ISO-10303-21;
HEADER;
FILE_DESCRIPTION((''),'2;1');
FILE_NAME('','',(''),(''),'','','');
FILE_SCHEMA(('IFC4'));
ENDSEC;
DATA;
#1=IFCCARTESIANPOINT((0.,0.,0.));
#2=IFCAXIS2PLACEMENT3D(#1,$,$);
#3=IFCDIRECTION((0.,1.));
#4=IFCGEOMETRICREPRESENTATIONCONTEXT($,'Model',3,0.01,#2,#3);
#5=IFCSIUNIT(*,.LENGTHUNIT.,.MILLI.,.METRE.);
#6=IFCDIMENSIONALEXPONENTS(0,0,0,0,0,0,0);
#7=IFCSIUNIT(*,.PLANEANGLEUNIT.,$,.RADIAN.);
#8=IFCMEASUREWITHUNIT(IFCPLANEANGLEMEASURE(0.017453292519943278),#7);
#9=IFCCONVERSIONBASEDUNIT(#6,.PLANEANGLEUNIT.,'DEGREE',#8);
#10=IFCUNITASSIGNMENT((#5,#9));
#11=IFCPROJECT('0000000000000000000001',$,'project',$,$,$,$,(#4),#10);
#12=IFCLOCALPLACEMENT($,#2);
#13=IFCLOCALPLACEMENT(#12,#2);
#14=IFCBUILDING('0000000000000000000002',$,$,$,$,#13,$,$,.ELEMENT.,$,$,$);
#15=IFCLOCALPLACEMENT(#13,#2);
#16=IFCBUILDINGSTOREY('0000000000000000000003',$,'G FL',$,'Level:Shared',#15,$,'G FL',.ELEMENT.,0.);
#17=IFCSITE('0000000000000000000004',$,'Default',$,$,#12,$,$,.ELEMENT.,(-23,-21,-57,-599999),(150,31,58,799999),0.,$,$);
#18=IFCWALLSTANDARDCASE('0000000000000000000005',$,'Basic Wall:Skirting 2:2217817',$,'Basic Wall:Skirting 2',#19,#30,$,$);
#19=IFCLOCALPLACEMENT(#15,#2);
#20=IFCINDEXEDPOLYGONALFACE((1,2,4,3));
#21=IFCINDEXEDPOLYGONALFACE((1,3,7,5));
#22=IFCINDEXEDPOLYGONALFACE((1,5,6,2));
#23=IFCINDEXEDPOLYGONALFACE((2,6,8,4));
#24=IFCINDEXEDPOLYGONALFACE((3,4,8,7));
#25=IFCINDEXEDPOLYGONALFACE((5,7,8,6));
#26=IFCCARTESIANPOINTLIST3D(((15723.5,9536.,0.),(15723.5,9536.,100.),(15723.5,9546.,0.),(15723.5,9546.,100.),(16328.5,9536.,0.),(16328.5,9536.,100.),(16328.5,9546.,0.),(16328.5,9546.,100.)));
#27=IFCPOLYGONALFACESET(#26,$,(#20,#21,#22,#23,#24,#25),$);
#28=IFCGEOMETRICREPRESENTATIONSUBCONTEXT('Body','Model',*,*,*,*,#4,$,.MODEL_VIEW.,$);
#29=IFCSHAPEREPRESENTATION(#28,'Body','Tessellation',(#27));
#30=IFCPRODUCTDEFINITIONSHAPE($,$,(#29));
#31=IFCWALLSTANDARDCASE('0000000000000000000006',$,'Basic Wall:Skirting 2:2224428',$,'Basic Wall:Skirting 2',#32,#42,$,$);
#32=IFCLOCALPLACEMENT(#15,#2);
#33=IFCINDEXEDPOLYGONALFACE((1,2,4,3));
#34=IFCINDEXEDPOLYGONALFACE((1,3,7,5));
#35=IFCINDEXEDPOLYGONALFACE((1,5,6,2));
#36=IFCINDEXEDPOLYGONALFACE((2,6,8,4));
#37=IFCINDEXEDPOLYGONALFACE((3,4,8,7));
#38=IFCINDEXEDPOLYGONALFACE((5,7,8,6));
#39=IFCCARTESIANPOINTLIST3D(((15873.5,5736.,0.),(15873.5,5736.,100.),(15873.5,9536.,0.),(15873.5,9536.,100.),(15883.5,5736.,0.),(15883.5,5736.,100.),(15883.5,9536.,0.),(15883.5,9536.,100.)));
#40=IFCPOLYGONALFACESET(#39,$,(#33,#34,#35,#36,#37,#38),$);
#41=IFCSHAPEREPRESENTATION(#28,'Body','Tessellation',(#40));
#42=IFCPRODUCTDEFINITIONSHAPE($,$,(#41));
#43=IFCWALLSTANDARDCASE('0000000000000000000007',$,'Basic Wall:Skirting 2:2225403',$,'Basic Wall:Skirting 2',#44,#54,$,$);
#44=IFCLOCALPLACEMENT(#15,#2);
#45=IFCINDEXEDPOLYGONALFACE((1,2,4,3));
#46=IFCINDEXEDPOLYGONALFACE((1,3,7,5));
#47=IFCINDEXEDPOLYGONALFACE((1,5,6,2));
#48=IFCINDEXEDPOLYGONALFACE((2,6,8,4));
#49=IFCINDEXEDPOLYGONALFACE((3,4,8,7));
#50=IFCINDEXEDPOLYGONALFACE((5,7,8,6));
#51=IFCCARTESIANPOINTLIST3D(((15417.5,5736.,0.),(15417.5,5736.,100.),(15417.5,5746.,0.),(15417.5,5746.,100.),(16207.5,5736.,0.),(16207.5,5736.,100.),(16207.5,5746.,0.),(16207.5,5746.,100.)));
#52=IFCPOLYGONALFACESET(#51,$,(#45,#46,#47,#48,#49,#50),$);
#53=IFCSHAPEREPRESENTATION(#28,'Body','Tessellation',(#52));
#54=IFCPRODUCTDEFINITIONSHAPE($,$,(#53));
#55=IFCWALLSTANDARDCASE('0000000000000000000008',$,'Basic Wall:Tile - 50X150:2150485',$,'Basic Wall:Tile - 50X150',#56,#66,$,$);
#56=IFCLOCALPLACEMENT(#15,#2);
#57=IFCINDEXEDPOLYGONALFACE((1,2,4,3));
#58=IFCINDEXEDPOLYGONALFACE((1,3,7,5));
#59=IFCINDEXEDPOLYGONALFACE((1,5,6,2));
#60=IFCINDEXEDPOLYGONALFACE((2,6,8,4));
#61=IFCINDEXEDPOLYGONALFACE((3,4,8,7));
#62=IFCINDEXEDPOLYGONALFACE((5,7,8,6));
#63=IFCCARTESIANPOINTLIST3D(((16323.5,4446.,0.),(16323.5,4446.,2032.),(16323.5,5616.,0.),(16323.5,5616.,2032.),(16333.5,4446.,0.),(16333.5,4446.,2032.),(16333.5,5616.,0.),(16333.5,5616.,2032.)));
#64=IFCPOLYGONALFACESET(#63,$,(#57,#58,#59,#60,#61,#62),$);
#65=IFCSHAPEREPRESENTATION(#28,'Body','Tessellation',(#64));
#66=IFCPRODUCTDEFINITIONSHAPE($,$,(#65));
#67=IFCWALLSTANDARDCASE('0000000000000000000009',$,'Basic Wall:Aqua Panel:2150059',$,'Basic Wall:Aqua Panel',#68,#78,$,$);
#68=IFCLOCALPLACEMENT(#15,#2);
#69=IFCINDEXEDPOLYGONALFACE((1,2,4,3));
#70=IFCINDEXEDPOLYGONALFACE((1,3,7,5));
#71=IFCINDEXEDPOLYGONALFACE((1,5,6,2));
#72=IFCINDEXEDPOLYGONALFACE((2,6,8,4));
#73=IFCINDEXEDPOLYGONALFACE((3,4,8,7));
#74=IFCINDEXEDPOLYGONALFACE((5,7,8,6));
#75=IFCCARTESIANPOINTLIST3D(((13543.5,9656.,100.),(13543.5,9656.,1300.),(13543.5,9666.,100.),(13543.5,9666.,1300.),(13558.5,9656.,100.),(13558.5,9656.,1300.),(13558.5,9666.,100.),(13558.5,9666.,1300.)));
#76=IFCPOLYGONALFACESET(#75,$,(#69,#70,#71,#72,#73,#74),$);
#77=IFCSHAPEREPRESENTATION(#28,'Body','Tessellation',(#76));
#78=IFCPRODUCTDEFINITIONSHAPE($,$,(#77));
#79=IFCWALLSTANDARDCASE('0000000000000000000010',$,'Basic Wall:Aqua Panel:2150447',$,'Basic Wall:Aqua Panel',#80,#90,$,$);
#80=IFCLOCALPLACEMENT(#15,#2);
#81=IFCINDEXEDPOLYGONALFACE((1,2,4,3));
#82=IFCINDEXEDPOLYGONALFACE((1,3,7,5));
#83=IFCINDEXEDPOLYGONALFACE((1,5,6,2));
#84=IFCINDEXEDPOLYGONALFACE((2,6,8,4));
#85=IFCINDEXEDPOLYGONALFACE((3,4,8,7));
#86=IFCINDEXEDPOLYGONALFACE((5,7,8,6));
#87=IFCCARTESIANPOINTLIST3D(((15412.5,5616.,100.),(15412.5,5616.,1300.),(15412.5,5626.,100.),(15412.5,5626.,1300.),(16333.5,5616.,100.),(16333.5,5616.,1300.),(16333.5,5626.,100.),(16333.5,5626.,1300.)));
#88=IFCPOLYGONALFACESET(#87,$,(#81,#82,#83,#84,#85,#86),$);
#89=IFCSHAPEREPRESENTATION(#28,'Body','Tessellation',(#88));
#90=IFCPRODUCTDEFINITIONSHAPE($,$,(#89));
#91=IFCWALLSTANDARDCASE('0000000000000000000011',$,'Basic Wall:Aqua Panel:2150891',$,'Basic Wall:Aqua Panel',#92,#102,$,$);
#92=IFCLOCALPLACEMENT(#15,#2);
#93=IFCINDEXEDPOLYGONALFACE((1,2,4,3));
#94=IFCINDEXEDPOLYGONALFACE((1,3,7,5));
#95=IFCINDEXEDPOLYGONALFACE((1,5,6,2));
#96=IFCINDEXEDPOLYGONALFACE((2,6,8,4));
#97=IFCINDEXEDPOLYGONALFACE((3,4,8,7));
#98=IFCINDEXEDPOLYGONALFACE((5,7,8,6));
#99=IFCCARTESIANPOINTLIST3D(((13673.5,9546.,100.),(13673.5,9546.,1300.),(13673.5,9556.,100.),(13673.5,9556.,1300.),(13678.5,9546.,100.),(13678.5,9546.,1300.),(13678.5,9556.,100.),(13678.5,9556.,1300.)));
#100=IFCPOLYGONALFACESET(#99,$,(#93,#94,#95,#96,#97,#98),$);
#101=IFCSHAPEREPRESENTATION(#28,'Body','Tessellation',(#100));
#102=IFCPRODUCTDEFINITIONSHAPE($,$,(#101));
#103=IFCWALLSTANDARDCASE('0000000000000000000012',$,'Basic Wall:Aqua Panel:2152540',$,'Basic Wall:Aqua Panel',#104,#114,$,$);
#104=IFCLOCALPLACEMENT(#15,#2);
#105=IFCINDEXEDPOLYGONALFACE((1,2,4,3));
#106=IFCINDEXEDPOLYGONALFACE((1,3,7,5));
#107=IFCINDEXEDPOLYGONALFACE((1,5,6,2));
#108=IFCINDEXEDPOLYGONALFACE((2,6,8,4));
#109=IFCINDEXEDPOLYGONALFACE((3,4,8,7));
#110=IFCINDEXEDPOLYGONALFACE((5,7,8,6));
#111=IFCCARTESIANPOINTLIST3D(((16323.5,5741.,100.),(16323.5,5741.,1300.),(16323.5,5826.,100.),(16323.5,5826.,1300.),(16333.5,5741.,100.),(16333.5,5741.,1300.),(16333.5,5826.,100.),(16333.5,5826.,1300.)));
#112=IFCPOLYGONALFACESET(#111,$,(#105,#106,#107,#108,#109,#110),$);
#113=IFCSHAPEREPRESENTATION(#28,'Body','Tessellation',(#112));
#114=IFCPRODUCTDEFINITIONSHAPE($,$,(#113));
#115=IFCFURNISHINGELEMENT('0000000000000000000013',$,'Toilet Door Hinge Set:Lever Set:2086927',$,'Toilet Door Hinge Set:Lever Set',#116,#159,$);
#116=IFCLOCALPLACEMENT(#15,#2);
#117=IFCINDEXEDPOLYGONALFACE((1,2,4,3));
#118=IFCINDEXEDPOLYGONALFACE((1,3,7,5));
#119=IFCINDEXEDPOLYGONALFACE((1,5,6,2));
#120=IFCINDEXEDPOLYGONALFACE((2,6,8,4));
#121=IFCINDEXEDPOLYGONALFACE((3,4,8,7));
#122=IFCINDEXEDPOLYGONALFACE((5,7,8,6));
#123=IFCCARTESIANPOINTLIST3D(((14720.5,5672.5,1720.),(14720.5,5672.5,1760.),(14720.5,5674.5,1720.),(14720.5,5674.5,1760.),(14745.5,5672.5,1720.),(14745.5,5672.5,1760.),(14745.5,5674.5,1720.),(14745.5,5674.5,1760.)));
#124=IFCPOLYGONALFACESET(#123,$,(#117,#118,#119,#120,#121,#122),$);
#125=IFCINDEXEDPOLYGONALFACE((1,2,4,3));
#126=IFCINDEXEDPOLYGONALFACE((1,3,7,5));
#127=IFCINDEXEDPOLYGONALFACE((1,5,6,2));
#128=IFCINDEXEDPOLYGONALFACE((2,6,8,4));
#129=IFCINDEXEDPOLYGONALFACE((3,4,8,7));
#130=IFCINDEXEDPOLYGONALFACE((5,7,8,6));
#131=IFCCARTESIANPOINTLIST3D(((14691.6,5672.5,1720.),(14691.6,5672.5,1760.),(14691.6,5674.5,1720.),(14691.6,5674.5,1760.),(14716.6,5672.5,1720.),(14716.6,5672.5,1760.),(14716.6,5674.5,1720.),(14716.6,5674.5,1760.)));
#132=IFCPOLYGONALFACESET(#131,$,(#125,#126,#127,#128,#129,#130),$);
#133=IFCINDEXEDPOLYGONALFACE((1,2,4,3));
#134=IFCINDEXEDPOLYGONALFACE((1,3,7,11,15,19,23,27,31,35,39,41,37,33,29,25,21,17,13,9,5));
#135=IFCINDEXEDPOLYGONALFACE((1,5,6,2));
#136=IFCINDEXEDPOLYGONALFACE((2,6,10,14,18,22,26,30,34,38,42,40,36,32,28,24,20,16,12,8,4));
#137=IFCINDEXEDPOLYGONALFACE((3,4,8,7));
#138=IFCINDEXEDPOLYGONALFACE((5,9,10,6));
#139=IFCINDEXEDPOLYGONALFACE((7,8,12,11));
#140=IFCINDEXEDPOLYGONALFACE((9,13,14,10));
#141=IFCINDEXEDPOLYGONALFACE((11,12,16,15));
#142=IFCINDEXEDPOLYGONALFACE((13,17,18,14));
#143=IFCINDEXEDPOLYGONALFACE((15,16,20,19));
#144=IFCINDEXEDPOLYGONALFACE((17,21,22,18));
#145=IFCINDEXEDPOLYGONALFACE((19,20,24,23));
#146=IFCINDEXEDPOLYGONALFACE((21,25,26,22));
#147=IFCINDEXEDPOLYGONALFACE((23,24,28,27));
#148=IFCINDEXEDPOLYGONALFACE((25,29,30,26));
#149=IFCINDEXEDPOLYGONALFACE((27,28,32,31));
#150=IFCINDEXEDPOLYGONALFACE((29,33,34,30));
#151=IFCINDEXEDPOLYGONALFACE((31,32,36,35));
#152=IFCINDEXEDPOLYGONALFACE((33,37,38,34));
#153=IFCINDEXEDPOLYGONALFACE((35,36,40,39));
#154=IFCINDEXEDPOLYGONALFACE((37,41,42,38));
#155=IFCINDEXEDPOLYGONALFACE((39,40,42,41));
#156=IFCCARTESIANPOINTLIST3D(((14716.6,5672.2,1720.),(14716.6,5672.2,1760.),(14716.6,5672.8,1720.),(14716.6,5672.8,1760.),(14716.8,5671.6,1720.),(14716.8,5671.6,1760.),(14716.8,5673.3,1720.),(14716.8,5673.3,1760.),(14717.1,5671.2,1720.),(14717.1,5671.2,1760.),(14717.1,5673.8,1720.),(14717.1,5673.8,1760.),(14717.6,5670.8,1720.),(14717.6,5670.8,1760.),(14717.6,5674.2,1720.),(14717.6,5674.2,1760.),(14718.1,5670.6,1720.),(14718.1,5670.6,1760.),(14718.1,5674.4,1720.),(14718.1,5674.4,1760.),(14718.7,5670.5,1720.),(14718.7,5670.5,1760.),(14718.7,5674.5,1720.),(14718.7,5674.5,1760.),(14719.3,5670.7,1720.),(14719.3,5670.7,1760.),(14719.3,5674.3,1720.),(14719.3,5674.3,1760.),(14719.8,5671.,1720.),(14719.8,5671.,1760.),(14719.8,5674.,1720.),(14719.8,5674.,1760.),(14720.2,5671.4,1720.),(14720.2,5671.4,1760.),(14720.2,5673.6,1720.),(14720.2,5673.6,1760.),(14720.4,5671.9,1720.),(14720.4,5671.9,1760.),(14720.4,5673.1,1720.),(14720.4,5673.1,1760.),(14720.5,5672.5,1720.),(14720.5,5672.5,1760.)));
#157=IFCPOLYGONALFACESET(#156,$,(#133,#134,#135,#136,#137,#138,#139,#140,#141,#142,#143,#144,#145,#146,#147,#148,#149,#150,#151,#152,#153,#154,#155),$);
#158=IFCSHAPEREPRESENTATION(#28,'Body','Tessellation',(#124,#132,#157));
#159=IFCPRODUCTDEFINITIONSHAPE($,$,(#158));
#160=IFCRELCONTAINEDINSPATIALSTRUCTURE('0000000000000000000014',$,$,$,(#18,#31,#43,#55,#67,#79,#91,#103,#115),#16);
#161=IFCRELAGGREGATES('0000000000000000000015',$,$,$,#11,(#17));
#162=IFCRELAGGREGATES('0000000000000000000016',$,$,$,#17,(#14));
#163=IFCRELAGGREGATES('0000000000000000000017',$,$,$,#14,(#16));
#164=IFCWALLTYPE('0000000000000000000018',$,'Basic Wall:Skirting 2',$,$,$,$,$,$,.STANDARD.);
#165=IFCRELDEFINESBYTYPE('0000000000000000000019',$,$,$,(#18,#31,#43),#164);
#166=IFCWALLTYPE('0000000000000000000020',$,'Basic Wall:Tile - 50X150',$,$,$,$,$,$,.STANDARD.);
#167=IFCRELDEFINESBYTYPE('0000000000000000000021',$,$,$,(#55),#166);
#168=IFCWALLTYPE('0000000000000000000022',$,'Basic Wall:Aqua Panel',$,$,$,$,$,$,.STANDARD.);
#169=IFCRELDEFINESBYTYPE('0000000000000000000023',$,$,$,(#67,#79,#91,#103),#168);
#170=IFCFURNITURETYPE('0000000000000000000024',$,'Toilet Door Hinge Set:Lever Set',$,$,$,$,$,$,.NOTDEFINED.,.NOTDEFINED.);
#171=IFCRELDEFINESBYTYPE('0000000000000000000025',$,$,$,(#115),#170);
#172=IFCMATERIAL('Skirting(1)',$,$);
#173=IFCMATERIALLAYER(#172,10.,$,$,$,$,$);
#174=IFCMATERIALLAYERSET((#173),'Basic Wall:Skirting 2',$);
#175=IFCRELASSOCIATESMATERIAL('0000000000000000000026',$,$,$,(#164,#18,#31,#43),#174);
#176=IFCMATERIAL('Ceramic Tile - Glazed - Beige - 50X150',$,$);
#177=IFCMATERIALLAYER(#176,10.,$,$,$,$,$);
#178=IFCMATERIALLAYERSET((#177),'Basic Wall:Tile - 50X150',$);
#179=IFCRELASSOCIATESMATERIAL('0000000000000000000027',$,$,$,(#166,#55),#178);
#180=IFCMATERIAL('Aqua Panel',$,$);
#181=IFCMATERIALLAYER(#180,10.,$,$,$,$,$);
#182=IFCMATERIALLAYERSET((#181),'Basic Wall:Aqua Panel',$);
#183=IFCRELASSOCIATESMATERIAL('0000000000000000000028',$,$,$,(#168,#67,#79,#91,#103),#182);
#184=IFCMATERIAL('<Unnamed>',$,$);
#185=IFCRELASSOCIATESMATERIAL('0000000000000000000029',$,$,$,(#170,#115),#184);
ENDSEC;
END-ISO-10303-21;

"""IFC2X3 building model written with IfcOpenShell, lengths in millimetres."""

from ifc_helpers import new_model, entity, si_unit, converted_unit, direction, frame, frame_2d, origin, place, context, subcontext, project, spatial, rectangle, circle, extrude, source, transform, mapped, material, layer, layer_set, layer_usage, type_object, type_shapes, element, save


model = new_model("IFC2X3")

# Units and contexts
model_context = context("Model", 3, precision=0.01, world=origin(), true_north=direction((0.0, 1.0)))
body_context = subcontext(model_context, "Body", "Model", "MODEL_VIEW")
ifc_project = project(units=[si_unit("LENGTHUNIT", "METRE", prefix="MILLI"), converted_unit("PLANEANGLEUNIT", "DEGREE", entity("IfcPlaneAngleMeasure", 0.017453292519943278), si_unit("PLANEANGLEUNIT", "RADIAN"), dimensions=[0, 0, 0, 0, 0, 0, 0])], contexts=[model_context])

# Site, building, storey
site_placement = place(None, origin())
site = spatial("IfcSite", under=ifc_project, at=site_placement, Name="Default", CompositionType="ELEMENT", RefLatitude=(-23, -21, -57, -599999), RefLongitude=(150, 31, 58, 799999), RefElevation=0.0)
building_placement = place(site_placement, origin())
building = spatial("IfcBuilding", under=site, at=building_placement, CompositionType="ELEMENT")
storey_placement = place(building_placement, origin())
storey = spatial("IfcBuildingStorey", under=building, at=storey_placement, Name="G FL", ObjectType="Level:Shared", LongName="G FL", CompositionType="ELEMENT", Elevation=0.0)

# Walls
ifc_material_1 = material(Name="Skirting(1)")
ifc_layer_1 = layer(ifc_material_1, 10.0)
ifc_layer_set_1 = layer_set([ifc_layer_1], Name="Basic Wall:Skirting 2")
wall_type_1 = type_object("IfcWallType", Name="Basic Wall:Skirting 2", PredefinedType="STANDARD", material=ifc_layer_set_1)
ifc_layer_usage_1 = layer_usage(ifc_layer_set_1, "AXIS2", "POSITIVE", -5.0)
wall_1_placement = place(storey_placement, frame((16328.5, 9541.0, 0.0), z_axis=(0.0, 0.0, 1.0), x_axis=(-1.0, 0.0, 0.0)))
element("IfcWallStandardCase", 1, at=wall_1_placement, inside=storey, type_object=wall_type_1, material=ifc_layer_usage_1, Name="Basic Wall:Skirting 2:2217817", ObjectType="Basic Wall:Skirting 2", context=body_context, shape_type="SweptSolid", body=[
    extrude(rectangle(XDim=605.0, YDim=10.0, at=frame_2d((302.5, 0.0), x_axis=(-1.0, 0.0))), origin(), (0.0, 0.0, 1.0), 100.0),
])
ifc_layer_usage_2 = layer_usage(ifc_layer_set_1, "AXIS2", "POSITIVE", -5.0)
wall_2_placement = place(storey_placement, frame((15878.5, 9536.0, 0.0), z_axis=(0.0, 0.0, 1.0), x_axis=(0.0, -1.0, 0.0)))
element("IfcWallStandardCase", 2, at=wall_2_placement, inside=storey, type_object=wall_type_1, material=ifc_layer_usage_2, Name="Basic Wall:Skirting 2:2224428", ObjectType="Basic Wall:Skirting 2", context=body_context, shape_type="SweptSolid", body=[
    extrude(rectangle(XDim=3800.0, YDim=10.0, at=frame_2d((1900.0, 0.0), x_axis=(-1.0, 0.0))), origin(), (0.0, 0.0, 1.0), 100.0),
])
ifc_layer_usage_3 = layer_usage(ifc_layer_set_1, "AXIS2", "POSITIVE", -5.0)
wall_3_placement = place(storey_placement, frame((15417.5, 5741.0, 0.0)))
element("IfcWallStandardCase", 3, at=wall_3_placement, inside=storey, type_object=wall_type_1, material=ifc_layer_usage_3, Name="Basic Wall:Skirting 2:2225403", ObjectType="Basic Wall:Skirting 2", context=body_context, shape_type="SweptSolid", body=[
    extrude(rectangle(XDim=790.0, YDim=10.0, at=frame_2d((395.0, 0.0), x_axis=(-1.0, 0.0))), origin(), (0.0, 0.0, 1.0), 100.0),
])
ifc_material_2 = material(Name="Ceramic Tile - Glazed - Beige - 50X150")
ifc_layer_2 = layer(ifc_material_2, 10.0)
ifc_layer_set_2 = layer_set([ifc_layer_2], Name="Basic Wall:Tile - 50X150")
ifc_layer_usage_4 = layer_usage(ifc_layer_set_2, "AXIS2", "NEGATIVE", 5.0)
wall_type_2 = type_object("IfcWallType", Name="Basic Wall:Tile - 50X150", PredefinedType="STANDARD", material=ifc_layer_set_2)
wall_4_placement = place(storey_placement, frame((16328.5, 5616.0, 0.0), z_axis=(0.0, 0.0, 1.0), x_axis=(0.0, -1.0, 0.0)))
element("IfcWallStandardCase", 4, at=wall_4_placement, inside=storey, type_object=wall_type_2, material=ifc_layer_usage_4, Name="Basic Wall:Tile - 50X150:2150485", ObjectType="Basic Wall:Tile - 50X150", context=body_context, shape_type="SweptSolid", body=[
    extrude(rectangle(XDim=1170.0, YDim=10.0, at=frame_2d((585.0, 0.0), x_axis=(-1.0, 0.0))), origin(), (0.0, 0.0, 1.0), 2032.0),
])
ifc_material_3 = material(Name="Aqua Panel")
ifc_layer_3 = layer(ifc_material_3, 10.0)
ifc_layer_set_3 = layer_set([ifc_layer_3], Name="Basic Wall:Aqua Panel")
ifc_layer_usage_5 = layer_usage(ifc_layer_set_3, "AXIS2", "NEGATIVE", 5.0)
wall_type_3 = type_object("IfcWallType", Name="Basic Wall:Aqua Panel", PredefinedType="STANDARD", material=ifc_layer_set_3)
wall_5_placement = place(storey_placement, frame((13558.5, 9661.0, 100.0), z_axis=(0.0, 0.0, 1.0), x_axis=(-1.0, 0.0, 0.0)))
element("IfcWallStandardCase", 5, at=wall_5_placement, inside=storey, type_object=wall_type_3, material=ifc_layer_usage_5, Name="Basic Wall:Aqua Panel:2150059", ObjectType="Basic Wall:Aqua Panel", context=body_context, shape_type="SweptSolid", body=[
    extrude(rectangle(XDim=15.0, YDim=10.0, at=frame_2d((0.0, 0.0), x_axis=(1.0, 0.0))), frame((7.5, 0.0, 0.0)), (0.0, 0.0, 1.0), 1200.0),
])
ifc_layer_usage_6 = layer_usage(ifc_layer_set_3, "AXIS2", "NEGATIVE", 5.0)
wall_6_placement = place(storey_placement, frame((15412.5, 5621.0, 100.0)))
element("IfcWallStandardCase", 6, at=wall_6_placement, inside=storey, type_object=wall_type_3, material=ifc_layer_usage_6, Name="Basic Wall:Aqua Panel:2150447", ObjectType="Basic Wall:Aqua Panel", context=body_context, shape_type="SweptSolid", body=[
    extrude(rectangle(XDim=921.0, YDim=10.0, at=frame_2d((460.5, 0.0), x_axis=(-1.0, 0.0))), origin(), (0.0, 0.0, 1.0), 1200.0),
])
ifc_layer_usage_7 = layer_usage(ifc_layer_set_3, "AXIS2", "NEGATIVE", 5.0)
wall_7_placement = place(storey_placement, frame((13673.5, 9551.0, 100.0)))
element("IfcWallStandardCase", 7, at=wall_7_placement, inside=storey, type_object=wall_type_3, material=ifc_layer_usage_7, Name="Basic Wall:Aqua Panel:2150891", ObjectType="Basic Wall:Aqua Panel", context=body_context, shape_type="SweptSolid", body=[
    extrude(rectangle(XDim=5.0, YDim=10.0, at=frame_2d((0.0, 0.0), x_axis=(1.0, 0.0))), frame((2.5, 0.0, 0.0), z_axis=(0.0, 0.0, 1.0), x_axis=(-1.0, 0.0, 0.0)), (0.0, 0.0, 1.0), 1200.0),
])
ifc_layer_usage_8 = layer_usage(ifc_layer_set_3, "AXIS2", "NEGATIVE", 5.0)
wall_8_placement = place(storey_placement, frame((16328.5, 5826.0, 100.0), z_axis=(0.0, 0.0, 1.0), x_axis=(0.0, -1.0, 0.0)))
element("IfcWallStandardCase", 8, at=wall_8_placement, inside=storey, type_object=wall_type_3, material=ifc_layer_usage_8, Name="Basic Wall:Aqua Panel:2152540", ObjectType="Basic Wall:Aqua Panel", context=body_context, shape_type="SweptSolid", body=[
    extrude(rectangle(XDim=85.0, YDim=10.0, at=frame_2d((42.5, 0.0), x_axis=(-1.0, 0.0))), origin(), (0.0, 0.0, 1.0), 1200.0),
])

# Furnishing element
ifc_material_4 = material(Name="<Unnamed>")
furniture_type = type_object("IfcFurnitureType", Name="Toilet Door Hinge Set:Lever Set", AssemblyPlace="NOTDEFINED", material=ifc_material_4)
shared_shape_1 = source(origin(), body_context, "Body", "SweptSolid", [
    extrude(rectangle(XDim=2.0, YDim=25.0, at=frame_2d((0.0, 0.0), x_axis=(1.0, 0.0))), frame((14.5, 1.0, -20.0), z_axis=(0.0, 0.0, 1.0), x_axis=(0.0, 1.0, 0.0)), (0.0, 0.0, 1.0), 40.0),
    extrude(rectangle(XDim=25.0, YDim=2.0, at=frame_2d((0.0, 0.0), x_axis=(1.0, 0.0))), frame((-14.5, 1.0, -20.0)), (0.0, 0.0, 1.0), 40.0),
    extrude(circle(Radius=2.0, at=frame_2d((0.0, 0.0), x_axis=(1.0, 0.0))), frame((0.0, 0.0, -20.0)), (0.0, 0.0, 1.0), 40.0),
])
type_shapes(furniture_type, [shared_shape_1])
for number, where, name in (
    (9, (14718.5, 5672.5, 1740.0), "Toilet Door Hinge Set:Lever Set:2086927"),
):
    element("IfcFurnishingElement", number, at=place(storey_placement, frame(where)), inside=storey, type_object=furniture_type, material=ifc_material_4, Name=name, ObjectType="Toilet Door Hinge Set:Lever Set", context=body_context, shape_type="MappedRepresentation", body=[
        mapped(shared_shape_1, transform((0.0, 0.0, 0.0), scale=1.0)),
    ])

save(model, "model.ifc")
